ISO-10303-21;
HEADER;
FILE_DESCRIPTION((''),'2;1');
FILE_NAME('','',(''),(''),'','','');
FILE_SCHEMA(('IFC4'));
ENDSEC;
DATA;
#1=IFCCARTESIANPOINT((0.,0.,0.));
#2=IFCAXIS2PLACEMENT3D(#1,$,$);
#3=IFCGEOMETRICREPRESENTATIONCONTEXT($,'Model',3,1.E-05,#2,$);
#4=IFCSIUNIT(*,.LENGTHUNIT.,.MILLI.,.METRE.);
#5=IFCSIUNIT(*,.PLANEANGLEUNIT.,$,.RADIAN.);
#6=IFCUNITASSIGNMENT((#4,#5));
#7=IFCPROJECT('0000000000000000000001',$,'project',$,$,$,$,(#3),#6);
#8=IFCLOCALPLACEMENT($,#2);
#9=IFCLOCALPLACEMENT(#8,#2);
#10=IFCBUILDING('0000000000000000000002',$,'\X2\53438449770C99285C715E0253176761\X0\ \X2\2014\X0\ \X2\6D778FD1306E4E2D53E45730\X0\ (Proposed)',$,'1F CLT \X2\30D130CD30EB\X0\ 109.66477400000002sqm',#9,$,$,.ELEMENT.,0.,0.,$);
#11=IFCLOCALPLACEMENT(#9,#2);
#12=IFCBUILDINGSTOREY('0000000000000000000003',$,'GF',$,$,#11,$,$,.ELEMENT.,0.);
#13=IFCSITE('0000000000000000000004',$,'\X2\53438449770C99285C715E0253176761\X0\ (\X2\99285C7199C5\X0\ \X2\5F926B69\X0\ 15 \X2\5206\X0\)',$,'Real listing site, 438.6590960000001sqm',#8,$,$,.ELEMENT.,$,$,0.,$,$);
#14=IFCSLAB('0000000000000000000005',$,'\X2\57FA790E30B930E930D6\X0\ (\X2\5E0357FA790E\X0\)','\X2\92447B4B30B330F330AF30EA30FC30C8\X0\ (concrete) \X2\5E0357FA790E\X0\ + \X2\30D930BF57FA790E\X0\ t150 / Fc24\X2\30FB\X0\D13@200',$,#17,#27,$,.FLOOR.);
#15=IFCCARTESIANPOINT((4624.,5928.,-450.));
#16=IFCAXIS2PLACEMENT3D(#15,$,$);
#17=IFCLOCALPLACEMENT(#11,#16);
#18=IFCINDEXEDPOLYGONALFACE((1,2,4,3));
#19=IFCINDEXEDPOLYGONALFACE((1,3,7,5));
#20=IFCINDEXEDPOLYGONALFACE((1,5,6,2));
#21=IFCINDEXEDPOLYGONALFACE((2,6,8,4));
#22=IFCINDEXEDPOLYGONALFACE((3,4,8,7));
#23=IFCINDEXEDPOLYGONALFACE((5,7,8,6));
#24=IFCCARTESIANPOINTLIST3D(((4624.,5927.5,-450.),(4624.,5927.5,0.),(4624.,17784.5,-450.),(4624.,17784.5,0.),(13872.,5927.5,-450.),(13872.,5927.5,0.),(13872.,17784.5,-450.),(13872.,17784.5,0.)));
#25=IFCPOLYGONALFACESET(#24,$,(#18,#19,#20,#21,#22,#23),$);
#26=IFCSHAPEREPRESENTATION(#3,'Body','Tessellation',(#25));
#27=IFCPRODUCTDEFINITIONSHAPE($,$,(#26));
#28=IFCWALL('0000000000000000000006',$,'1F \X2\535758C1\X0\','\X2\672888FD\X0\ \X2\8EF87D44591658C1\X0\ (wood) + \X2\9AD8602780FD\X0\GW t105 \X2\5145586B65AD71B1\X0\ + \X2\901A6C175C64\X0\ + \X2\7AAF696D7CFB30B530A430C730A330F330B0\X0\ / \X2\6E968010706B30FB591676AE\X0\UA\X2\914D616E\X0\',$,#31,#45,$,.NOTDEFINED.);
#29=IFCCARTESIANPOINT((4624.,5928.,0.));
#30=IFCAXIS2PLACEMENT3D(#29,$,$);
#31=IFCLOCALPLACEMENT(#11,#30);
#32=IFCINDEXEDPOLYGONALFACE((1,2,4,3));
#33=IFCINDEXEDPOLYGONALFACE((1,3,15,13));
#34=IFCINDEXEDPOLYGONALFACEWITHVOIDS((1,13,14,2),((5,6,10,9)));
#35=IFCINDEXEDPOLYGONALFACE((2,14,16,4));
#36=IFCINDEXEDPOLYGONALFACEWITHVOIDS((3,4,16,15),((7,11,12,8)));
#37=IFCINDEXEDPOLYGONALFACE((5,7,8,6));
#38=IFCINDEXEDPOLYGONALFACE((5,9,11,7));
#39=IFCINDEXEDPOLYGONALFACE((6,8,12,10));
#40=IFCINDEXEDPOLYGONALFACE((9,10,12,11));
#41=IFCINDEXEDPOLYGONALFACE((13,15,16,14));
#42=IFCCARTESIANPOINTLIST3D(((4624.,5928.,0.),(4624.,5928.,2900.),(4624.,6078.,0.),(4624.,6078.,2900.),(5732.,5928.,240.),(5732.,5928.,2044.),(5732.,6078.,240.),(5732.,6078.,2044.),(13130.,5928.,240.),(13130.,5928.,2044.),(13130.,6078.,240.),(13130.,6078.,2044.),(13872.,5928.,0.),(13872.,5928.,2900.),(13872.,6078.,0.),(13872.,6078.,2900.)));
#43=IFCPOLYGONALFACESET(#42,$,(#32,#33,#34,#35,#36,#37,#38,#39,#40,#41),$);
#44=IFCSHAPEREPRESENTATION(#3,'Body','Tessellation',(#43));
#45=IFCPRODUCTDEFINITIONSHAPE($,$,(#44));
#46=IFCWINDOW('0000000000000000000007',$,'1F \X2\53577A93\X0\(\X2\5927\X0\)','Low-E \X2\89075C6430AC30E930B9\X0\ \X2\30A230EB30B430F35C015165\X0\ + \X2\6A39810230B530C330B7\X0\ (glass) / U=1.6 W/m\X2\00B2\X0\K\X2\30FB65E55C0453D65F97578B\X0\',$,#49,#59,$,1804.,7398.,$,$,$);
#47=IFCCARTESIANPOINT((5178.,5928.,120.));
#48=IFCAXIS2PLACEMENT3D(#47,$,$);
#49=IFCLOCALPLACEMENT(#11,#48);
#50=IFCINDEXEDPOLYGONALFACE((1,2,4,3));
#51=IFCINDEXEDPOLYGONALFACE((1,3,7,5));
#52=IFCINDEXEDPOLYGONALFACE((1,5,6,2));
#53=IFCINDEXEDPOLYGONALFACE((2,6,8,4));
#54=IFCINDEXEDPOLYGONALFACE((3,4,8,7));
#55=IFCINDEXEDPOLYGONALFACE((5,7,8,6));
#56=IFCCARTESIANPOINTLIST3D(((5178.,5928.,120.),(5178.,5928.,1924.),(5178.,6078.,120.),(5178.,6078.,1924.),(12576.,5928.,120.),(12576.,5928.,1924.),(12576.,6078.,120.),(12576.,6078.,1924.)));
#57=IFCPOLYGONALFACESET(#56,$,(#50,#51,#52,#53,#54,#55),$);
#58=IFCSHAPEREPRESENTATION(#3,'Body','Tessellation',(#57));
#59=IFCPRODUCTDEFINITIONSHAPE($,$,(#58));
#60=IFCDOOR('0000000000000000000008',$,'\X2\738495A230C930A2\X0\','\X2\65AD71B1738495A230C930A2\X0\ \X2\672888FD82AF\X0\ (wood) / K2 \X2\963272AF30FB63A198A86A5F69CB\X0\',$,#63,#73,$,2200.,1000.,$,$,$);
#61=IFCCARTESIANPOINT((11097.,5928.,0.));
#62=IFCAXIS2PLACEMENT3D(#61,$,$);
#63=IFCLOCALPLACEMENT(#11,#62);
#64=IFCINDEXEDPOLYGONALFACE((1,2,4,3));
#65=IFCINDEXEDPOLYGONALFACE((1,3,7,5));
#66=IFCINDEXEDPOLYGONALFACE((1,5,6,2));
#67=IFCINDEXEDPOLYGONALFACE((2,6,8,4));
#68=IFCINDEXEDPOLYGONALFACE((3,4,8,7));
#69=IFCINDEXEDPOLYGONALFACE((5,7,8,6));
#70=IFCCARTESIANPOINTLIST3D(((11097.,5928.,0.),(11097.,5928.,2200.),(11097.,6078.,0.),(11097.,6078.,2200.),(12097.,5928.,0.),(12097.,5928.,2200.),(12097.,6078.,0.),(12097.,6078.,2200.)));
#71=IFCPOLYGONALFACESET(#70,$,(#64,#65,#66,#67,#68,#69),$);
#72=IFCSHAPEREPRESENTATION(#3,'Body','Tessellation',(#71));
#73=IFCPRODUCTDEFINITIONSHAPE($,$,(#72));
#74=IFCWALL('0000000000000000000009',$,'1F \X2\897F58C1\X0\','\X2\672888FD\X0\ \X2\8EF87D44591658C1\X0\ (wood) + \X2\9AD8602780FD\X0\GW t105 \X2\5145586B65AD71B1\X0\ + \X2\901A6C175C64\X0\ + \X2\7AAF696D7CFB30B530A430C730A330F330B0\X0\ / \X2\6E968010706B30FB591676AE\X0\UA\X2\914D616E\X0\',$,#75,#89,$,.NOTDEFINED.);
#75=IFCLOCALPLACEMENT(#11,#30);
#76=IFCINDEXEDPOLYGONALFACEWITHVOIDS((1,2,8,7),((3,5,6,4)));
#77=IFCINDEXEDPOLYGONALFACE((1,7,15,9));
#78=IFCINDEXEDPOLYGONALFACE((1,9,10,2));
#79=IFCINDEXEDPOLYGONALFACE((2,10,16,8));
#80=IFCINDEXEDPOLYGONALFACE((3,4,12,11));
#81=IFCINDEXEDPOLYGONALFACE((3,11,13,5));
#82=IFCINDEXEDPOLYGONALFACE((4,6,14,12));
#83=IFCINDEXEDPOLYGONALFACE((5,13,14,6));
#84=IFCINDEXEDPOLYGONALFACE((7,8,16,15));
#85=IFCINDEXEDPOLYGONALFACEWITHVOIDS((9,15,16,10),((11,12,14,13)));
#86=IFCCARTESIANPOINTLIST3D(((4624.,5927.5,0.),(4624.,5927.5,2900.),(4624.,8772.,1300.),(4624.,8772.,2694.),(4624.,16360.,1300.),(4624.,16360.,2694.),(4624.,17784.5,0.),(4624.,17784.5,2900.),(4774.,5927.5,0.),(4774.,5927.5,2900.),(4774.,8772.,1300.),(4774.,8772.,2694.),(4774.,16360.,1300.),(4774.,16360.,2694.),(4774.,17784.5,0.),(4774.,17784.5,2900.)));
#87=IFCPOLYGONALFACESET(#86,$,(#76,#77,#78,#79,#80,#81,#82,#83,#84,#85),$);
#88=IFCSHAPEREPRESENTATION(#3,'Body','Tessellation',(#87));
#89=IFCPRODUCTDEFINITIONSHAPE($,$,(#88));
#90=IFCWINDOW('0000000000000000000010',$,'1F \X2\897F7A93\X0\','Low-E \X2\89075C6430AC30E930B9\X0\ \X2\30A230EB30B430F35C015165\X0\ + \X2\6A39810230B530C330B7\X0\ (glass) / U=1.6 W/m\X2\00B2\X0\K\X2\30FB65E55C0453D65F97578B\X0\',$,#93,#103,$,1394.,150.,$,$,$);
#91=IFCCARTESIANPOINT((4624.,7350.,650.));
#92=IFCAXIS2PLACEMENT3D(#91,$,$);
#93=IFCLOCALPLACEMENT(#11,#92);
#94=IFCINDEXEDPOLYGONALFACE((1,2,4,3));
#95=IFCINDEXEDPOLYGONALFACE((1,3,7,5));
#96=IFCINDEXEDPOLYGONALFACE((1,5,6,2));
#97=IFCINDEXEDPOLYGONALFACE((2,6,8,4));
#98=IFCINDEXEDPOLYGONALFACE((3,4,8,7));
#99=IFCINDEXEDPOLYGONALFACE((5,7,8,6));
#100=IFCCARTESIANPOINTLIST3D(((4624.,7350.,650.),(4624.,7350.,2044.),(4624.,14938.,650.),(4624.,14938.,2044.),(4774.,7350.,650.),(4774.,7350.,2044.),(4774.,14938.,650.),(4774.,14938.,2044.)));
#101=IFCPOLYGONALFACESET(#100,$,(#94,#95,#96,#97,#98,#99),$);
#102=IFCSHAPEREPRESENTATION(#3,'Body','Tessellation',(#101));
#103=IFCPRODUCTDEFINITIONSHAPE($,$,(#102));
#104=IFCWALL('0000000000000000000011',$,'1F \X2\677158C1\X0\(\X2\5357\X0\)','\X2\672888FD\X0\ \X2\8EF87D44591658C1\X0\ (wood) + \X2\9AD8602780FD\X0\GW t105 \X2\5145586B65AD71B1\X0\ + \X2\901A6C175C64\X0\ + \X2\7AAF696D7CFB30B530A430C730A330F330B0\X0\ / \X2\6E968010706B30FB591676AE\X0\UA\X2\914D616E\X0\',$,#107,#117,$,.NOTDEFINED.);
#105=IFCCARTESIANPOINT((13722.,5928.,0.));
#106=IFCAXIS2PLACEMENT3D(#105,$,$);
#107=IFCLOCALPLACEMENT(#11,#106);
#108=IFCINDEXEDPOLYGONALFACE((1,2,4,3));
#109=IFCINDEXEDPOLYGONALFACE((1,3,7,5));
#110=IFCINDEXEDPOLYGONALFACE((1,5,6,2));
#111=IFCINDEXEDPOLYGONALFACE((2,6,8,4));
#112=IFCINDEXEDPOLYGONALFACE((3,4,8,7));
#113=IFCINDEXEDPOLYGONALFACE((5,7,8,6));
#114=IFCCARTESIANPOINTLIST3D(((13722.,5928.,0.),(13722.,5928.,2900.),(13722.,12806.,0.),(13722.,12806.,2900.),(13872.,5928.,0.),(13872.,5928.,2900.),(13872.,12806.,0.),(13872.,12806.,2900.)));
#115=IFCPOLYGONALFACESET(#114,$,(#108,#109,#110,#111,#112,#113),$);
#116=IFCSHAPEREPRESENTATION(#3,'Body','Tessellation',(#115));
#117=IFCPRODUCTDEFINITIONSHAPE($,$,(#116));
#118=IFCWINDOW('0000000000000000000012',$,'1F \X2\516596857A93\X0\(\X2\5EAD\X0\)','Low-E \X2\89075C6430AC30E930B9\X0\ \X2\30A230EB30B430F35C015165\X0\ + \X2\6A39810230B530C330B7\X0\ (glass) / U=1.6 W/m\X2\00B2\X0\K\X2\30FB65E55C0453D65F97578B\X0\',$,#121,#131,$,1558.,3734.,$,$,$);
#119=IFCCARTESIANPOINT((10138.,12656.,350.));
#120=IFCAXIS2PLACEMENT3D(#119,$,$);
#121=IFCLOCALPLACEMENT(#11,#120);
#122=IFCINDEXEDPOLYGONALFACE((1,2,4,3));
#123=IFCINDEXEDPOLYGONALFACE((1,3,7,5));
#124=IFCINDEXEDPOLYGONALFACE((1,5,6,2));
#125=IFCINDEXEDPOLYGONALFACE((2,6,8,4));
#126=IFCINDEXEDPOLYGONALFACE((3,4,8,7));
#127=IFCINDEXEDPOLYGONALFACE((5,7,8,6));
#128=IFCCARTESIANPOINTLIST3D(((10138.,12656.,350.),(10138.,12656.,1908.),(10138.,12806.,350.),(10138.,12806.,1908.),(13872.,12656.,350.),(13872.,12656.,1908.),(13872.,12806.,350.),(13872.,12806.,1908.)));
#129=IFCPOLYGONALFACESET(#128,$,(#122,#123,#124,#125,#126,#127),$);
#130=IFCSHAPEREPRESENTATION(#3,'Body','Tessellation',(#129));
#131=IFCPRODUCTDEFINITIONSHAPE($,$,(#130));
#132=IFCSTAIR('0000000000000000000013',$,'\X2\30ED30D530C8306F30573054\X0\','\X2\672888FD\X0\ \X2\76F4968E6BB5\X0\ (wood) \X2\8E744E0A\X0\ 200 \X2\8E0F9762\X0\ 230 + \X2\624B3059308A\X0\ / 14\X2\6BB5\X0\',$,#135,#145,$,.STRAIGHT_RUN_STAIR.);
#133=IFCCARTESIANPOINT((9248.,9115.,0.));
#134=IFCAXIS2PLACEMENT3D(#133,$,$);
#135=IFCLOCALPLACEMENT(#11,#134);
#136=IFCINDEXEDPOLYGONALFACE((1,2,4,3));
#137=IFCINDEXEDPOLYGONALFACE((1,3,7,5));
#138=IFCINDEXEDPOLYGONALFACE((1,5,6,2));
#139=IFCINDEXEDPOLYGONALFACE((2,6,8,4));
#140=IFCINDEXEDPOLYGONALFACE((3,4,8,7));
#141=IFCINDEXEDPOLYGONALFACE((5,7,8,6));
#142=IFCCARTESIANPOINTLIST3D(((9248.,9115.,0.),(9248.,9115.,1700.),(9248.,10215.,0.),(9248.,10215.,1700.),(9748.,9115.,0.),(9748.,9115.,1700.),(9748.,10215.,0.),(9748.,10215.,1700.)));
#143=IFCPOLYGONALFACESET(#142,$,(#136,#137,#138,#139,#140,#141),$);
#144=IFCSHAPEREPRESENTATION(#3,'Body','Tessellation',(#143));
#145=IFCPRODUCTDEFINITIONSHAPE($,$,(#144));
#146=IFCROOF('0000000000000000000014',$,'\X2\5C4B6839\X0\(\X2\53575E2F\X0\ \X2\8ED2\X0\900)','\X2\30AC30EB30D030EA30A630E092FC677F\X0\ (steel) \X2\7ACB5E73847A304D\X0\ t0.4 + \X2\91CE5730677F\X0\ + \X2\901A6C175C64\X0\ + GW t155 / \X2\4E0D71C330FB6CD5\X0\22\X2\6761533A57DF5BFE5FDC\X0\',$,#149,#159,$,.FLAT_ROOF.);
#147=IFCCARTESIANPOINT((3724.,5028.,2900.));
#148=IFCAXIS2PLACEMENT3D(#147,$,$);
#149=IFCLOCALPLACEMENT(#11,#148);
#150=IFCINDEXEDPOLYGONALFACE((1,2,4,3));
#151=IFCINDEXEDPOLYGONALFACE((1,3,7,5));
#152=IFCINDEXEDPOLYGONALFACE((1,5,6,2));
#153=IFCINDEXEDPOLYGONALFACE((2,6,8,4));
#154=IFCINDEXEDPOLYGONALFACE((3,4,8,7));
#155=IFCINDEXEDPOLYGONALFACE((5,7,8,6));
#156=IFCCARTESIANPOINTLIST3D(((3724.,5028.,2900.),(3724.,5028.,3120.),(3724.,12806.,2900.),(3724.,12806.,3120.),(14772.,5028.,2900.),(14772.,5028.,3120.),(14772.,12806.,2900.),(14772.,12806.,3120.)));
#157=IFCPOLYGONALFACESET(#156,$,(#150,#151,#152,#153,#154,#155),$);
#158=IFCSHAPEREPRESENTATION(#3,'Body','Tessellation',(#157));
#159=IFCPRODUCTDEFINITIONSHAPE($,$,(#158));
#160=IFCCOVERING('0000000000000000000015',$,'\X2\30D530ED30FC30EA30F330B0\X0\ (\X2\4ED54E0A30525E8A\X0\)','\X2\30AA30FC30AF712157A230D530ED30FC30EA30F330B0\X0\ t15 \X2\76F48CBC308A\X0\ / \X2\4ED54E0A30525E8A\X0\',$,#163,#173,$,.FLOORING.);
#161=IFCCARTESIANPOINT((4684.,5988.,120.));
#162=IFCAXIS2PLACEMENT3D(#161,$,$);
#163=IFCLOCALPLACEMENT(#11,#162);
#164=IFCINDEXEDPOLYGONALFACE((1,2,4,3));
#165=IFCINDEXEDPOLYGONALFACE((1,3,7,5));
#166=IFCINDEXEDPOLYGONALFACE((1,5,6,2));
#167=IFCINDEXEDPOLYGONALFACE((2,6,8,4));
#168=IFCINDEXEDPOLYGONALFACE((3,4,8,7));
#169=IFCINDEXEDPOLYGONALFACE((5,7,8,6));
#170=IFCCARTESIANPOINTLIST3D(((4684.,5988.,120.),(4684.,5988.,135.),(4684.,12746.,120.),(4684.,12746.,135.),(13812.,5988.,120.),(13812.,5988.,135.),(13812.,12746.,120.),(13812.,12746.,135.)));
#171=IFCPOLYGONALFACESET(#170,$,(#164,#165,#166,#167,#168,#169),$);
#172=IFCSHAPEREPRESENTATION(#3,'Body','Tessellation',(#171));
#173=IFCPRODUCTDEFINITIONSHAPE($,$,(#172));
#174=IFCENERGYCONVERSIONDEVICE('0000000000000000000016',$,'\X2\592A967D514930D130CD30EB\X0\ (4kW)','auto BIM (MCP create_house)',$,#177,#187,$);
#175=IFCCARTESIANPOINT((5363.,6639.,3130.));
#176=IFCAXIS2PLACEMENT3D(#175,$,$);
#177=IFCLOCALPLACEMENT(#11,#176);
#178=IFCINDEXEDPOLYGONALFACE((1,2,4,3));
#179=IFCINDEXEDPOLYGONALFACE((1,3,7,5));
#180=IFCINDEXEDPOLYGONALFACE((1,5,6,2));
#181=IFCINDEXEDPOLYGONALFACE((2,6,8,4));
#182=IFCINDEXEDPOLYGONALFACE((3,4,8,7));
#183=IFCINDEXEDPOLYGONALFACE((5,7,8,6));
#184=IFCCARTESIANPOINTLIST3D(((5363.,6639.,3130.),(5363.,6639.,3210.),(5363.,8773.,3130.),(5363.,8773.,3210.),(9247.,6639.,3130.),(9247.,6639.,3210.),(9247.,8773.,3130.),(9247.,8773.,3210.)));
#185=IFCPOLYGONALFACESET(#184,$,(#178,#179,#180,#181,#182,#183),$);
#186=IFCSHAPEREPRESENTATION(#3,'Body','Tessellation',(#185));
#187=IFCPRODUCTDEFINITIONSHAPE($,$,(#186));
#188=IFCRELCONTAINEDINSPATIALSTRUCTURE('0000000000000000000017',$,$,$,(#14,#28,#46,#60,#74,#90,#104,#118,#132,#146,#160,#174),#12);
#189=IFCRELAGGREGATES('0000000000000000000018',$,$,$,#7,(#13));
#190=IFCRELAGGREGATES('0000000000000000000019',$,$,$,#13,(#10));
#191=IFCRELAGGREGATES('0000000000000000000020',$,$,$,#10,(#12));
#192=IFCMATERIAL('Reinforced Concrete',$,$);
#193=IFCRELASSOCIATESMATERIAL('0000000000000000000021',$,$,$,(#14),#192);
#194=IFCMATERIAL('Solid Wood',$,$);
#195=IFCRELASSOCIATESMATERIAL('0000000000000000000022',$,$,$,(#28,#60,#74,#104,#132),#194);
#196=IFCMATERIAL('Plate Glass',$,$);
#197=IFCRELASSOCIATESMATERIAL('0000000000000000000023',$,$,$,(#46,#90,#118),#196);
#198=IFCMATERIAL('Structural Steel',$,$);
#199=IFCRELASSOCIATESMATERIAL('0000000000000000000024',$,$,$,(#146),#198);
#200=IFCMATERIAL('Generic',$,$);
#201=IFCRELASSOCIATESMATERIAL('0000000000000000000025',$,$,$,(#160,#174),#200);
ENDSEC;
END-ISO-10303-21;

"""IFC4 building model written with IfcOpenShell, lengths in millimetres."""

from ifc_helpers import new_model, si_unit, frame, frame_2d, origin, place, context, project, spatial, rectangle, extrude, material, element, fill, save


model = new_model("IFC4")

# Units and contexts
model_context = context("Model", 3, precision=1e-05, world=origin())
ifc_project = project(units=[si_unit("LENGTHUNIT", "METRE", prefix="MILLI"), si_unit("PLANEANGLEUNIT", "RADIAN")], contexts=[model_context])

# Site, building, storey
site_placement = place(None, origin())
site = spatial("IfcSite", under=ifc_project, at=site_placement, Name="千葉県館山市北条 (館山駅 徒歩 15 分)", ObjectType="Real listing site, 438.6590960000001sqm", CompositionType="ELEMENT", RefElevation=0.0)
building_placement = place(site_placement, origin())
building = spatial("IfcBuilding", under=site, at=building_placement, Name="千葉県館山市北条 — 海近の中古地 (Proposed)", ObjectType="1F CLT パネル 109.66477400000002sqm", CompositionType="ELEMENT", ElevationOfRefHeight=0.0, ElevationOfTerrain=0.0)
storey_placement = place(building_placement, origin())
storey = spatial("IfcBuildingStorey", under=building, at=storey_placement, Name="GF", CompositionType="ELEMENT", Elevation=0.0)

# Slab
ifc_material_1 = material(Name="Reinforced Concrete")
slab_1_placement = place(storey_placement, frame((4624.0, 5928.0, -450.0)))
element("IfcSlab", 1, at=slab_1_placement, inside=storey, material=ifc_material_1, Name="基礎スラブ (布基礎)", Description="鉄筋コンクリート (concrete) 布基礎 + ベタ基礎 t150 / Fc24・D13@200", PredefinedType="FLOOR", context=model_context, shape_type="SweptSolid", body=[
    extrude(rectangle(XDim=9248.0, YDim=11857.0, at=frame_2d((4624.0, 5928.0))), frame((4624.0, 5928.0, -450.0)), (0.0, 0.0, 1.0), 450.0),
])
ifc_material_2 = material(Name="Solid Wood")

# Wall, openings, window, door
wall_1_placement = place(storey_placement, frame((4624.0, 5928.0, 0.0)))
wall_1 = element("IfcWall", 2, at=wall_1_placement, inside=storey, material=ifc_material_2, Name="1F 南壁", Description="木製 軸組外壁 (wood) + 高性能GW t105 充填断熱 + 通気層 + 窯業系サイディング / 準耐火・外皮UA配慮", PredefinedType="NOTDEFINED", context=model_context, shape_type="SweptSolid", body=[
    extrude(rectangle(XDim=9248.0, YDim=150.0, at=frame_2d((4624.0, 75.0))), frame((4624.0, 5928.0, 0.0)), (0.0, 0.0, 1.0), 2900.0),
])
opening_1_placement = place(storey_placement, frame((5178.0, 5928.0, 120.0)))
opening_1 = element("IfcOpeningElement", 3, at=opening_1_placement, cuts=wall_1, PredefinedType="NOTDEFINED", context=model_context, shape_type="SweptSolid", body=[
    extrude(rectangle(XDim=7398.0, YDim=150.0, at=frame_2d((3699.0, 75.0))), frame((5178.0, 5928.0, 120.0)), (0.0, 0.0, 1.0), 1804.0),
])
opening_2_placement = place(storey_placement, frame((11097.0, 5928.0, 0.0)))
opening_2 = element("IfcOpeningElement", 4, at=opening_2_placement, cuts=wall_1, PredefinedType="NOTDEFINED", context=model_context, shape_type="SweptSolid", body=[
    extrude(rectangle(XDim=1000.0, YDim=150.0, at=frame_2d((500.0, 75.0))), frame((11097.0, 5928.0, 0.0)), (0.0, 0.0, 1.0), 2200.0),
])
ifc_material_3 = material(Name="Plate Glass")
window_1_placement = place(storey_placement, frame((5178.0, 5928.0, 120.0)))
window_1 = element("IfcWindow", 5, at=window_1_placement, inside=storey, material=ifc_material_3, Name="1F 南窓(大)", Description="Low-E 複層ガラス アルゴン封入 + 樹脂サッシ (glass) / U=1.6 W/m²K・日射取得型", OverallHeight=1804.0, OverallWidth=7398.0, context=model_context, shape_type="SweptSolid", body=[
    extrude(rectangle(XDim=7398.0, YDim=150.0, at=frame_2d((3699.0, 75.0))), frame((5178.0, 5928.0, 120.0)), (0.0, 0.0, 1.0), 1804.0),
])
fill(opening_1, window_1)
door_1_placement = place(storey_placement, frame((11097.0, 5928.0, 0.0)))
door_1 = element("IfcDoor", 6, at=door_1_placement, inside=storey, material=ifc_material_2, Name="玄関ドア", Description="断熱玄関ドア 木製芯 (wood) / K2 防犯・採風機構", OverallHeight=2200.0, OverallWidth=1000.0, context=model_context, shape_type="SweptSolid", body=[
    extrude(rectangle(XDim=1000.0, YDim=150.0, at=frame_2d((500.0, 75.0))), frame((11097.0, 5928.0, 0.0)), (0.0, 0.0, 1.0), 2200.0),
])
fill(opening_2, door_1)

# Walls, openings, windows
wall_2_placement = place(storey_placement, frame((4624.0, 5928.0, 0.0)))
wall_2 = element("IfcWall", 7, at=wall_2_placement, inside=storey, material=ifc_material_2, Name="1F 西壁", Description="木製 軸組外壁 (wood) + 高性能GW t105 充填断熱 + 通気層 + 窯業系サイディング / 準耐火・外皮UA配慮", PredefinedType="NOTDEFINED", context=model_context, shape_type="SweptSolid", body=[
    extrude(rectangle(XDim=150.0, YDim=11857.0, at=frame_2d((75.0, 5928.0))), frame((4624.0, 5928.0, 0.0)), (0.0, 0.0, 1.0), 2900.0),
])
opening_3_placement = place(storey_placement, frame((4624.0, 7350.0, 650.0)))
opening_3 = element("IfcOpeningElement", 8, at=opening_3_placement, cuts=wall_2, PredefinedType="NOTDEFINED", context=model_context, shape_type="SweptSolid", body=[
    extrude(rectangle(XDim=150.0, YDim=7588.0, at=frame_2d((75.0, 3794.0))), frame((4624.0, 7350.0, 650.0)), (0.0, 0.0, 1.0), 1394.0),
])
window_2_placement = place(storey_placement, frame((4624.0, 7350.0, 650.0)))
window_2 = element("IfcWindow", 9, at=window_2_placement, inside=storey, material=ifc_material_3, Name="1F 西窓", Description="Low-E 複層ガラス アルゴン封入 + 樹脂サッシ (glass) / U=1.6 W/m²K・日射取得型", OverallHeight=1394.0, OverallWidth=150.0, context=model_context, shape_type="SweptSolid", body=[
    extrude(rectangle(XDim=150.0, YDim=7588.0, at=frame_2d((75.0, 3794.0))), frame((4624.0, 7350.0, 650.0)), (0.0, 0.0, 1.0), 1394.0),
])
fill(opening_3, window_2)
wall_3_placement = place(storey_placement, frame((13722.0, 5928.0, 0.0)))
wall_3 = element("IfcWall", 10, at=wall_3_placement, inside=storey, material=ifc_material_2, Name="1F 東壁(南)", Description="木製 軸組外壁 (wood) + 高性能GW t105 充填断熱 + 通気層 + 窯業系サイディング / 準耐火・外皮UA配慮", PredefinedType="NOTDEFINED", context=model_context, shape_type="SweptSolid", body=[
    extrude(rectangle(XDim=150.0, YDim=6878.0, at=frame_2d((75.0, 3439.0))), frame((13722.0, 5928.0, 0.0)), (0.0, 0.0, 1.0), 2900.0),
])
opening_4_placement = place(storey_placement, frame((10138.0, 12656.0, 350.0)))
opening_4 = element("IfcOpeningElement", 11, at=opening_4_placement, cuts=wall_3, PredefinedType="NOTDEFINED", context=model_context, shape_type="SweptSolid", body=[
    extrude(rectangle(XDim=3734.0, YDim=150.0, at=frame_2d((1867.0, 75.0))), frame((10138.0, 12656.0, 350.0)), (0.0, 0.0, 1.0), 1558.0),
])
window_3_placement = place(storey_placement, frame((10138.0, 12656.0, 350.0)))
window_3 = element("IfcWindow", 12, at=window_3_placement, inside=storey, material=ifc_material_3, Name="1F 入隅窓(庭)", Description="Low-E 複層ガラス アルゴン封入 + 樹脂サッシ (glass) / U=1.6 W/m²K・日射取得型", OverallHeight=1558.0, OverallWidth=3734.0, context=model_context, shape_type="SweptSolid", body=[
    extrude(rectangle(XDim=3734.0, YDim=150.0, at=frame_2d((1867.0, 75.0))), frame((10138.0, 12656.0, 350.0)), (0.0, 0.0, 1.0), 1558.0),
])
fill(opening_4, window_3)

# Stair
stair_placement = place(storey_placement, frame((9248.0, 9115.0, 0.0)))
element("IfcStair", 13, at=stair_placement, inside=storey, material=ifc_material_2, Name="ロフトはしご", Description="木製 直階段 (wood) 蹴上 200 踏面 230 + 手すり / 14段", PredefinedType="STRAIGHT_RUN_STAIR", context=model_context, shape_type="SweptSolid", body=[
    extrude(rectangle(XDim=500.0, YDim=1100.0, at=frame_2d((250.0, 550.0))), frame((9248.0, 9115.0, 0.0)), (0.0, 0.0, 1.0), 1700.0),
])

# Roof
ifc_material_4 = material(Name="Structural Steel")
roof_placement = place(storey_placement, frame((3724.0, 5028.0, 2900.0)))
element("IfcRoof", 14, at=roof_placement, inside=storey, material=ifc_material_4, Name="屋根(南帯 軒900)", Description="ガルバリウム鋼板 (steel) 立平葺き t0.4 + 野地板 + 通気層 + GW t155 / 不燃・法22条区域対応", PredefinedType="FLAT_ROOF", context=model_context, shape_type="SweptSolid", body=[
    extrude(rectangle(XDim=11048.0, YDim=7778.0, at=frame_2d((5524.0, 3889.0))), frame((3724.0, 5028.0, 2900.0)), (0.0, 0.0, 1.0), 220.0),
])

# Covering
ifc_material_5 = material(Name="Generic")
covering_placement = place(storey_placement, frame((4684.0, 5988.0, 120.0)))
element("IfcCovering", 15, at=covering_placement, inside=storey, material=ifc_material_5, Name="フローリング (仕上げ床)", Description="オーク無垢フローリング t15 直貼り / 仕上げ床", PredefinedType="FLOORING", context=model_context, shape_type="SweptSolid", body=[
    extrude(rectangle(XDim=9128.0, YDim=6758.0, at=frame_2d((4564.0, 3379.0))), frame((4684.0, 5988.0, 120.0)), (0.0, 0.0, 1.0), 15.0),
])

# Energy conversion device
energy_conversion_device_placement = place(storey_placement, frame((5363.0, 6639.0, 3130.0)))
element("IfcEnergyConversionDevice", 16, at=energy_conversion_device_placement, inside=storey, material=ifc_material_5, Name="太陽光パネル (4kW)", Description="auto BIM (MCP create_house)", context=model_context, shape_type="SweptSolid", body=[
    extrude(rectangle(XDim=3884.0, YDim=2134.0, at=frame_2d((1942.0, 1067.0))), frame((5363.0, 6639.0, 3130.0)), (0.0, 0.0, 1.0), 80.0),
])

save(model, "model.ifc")
